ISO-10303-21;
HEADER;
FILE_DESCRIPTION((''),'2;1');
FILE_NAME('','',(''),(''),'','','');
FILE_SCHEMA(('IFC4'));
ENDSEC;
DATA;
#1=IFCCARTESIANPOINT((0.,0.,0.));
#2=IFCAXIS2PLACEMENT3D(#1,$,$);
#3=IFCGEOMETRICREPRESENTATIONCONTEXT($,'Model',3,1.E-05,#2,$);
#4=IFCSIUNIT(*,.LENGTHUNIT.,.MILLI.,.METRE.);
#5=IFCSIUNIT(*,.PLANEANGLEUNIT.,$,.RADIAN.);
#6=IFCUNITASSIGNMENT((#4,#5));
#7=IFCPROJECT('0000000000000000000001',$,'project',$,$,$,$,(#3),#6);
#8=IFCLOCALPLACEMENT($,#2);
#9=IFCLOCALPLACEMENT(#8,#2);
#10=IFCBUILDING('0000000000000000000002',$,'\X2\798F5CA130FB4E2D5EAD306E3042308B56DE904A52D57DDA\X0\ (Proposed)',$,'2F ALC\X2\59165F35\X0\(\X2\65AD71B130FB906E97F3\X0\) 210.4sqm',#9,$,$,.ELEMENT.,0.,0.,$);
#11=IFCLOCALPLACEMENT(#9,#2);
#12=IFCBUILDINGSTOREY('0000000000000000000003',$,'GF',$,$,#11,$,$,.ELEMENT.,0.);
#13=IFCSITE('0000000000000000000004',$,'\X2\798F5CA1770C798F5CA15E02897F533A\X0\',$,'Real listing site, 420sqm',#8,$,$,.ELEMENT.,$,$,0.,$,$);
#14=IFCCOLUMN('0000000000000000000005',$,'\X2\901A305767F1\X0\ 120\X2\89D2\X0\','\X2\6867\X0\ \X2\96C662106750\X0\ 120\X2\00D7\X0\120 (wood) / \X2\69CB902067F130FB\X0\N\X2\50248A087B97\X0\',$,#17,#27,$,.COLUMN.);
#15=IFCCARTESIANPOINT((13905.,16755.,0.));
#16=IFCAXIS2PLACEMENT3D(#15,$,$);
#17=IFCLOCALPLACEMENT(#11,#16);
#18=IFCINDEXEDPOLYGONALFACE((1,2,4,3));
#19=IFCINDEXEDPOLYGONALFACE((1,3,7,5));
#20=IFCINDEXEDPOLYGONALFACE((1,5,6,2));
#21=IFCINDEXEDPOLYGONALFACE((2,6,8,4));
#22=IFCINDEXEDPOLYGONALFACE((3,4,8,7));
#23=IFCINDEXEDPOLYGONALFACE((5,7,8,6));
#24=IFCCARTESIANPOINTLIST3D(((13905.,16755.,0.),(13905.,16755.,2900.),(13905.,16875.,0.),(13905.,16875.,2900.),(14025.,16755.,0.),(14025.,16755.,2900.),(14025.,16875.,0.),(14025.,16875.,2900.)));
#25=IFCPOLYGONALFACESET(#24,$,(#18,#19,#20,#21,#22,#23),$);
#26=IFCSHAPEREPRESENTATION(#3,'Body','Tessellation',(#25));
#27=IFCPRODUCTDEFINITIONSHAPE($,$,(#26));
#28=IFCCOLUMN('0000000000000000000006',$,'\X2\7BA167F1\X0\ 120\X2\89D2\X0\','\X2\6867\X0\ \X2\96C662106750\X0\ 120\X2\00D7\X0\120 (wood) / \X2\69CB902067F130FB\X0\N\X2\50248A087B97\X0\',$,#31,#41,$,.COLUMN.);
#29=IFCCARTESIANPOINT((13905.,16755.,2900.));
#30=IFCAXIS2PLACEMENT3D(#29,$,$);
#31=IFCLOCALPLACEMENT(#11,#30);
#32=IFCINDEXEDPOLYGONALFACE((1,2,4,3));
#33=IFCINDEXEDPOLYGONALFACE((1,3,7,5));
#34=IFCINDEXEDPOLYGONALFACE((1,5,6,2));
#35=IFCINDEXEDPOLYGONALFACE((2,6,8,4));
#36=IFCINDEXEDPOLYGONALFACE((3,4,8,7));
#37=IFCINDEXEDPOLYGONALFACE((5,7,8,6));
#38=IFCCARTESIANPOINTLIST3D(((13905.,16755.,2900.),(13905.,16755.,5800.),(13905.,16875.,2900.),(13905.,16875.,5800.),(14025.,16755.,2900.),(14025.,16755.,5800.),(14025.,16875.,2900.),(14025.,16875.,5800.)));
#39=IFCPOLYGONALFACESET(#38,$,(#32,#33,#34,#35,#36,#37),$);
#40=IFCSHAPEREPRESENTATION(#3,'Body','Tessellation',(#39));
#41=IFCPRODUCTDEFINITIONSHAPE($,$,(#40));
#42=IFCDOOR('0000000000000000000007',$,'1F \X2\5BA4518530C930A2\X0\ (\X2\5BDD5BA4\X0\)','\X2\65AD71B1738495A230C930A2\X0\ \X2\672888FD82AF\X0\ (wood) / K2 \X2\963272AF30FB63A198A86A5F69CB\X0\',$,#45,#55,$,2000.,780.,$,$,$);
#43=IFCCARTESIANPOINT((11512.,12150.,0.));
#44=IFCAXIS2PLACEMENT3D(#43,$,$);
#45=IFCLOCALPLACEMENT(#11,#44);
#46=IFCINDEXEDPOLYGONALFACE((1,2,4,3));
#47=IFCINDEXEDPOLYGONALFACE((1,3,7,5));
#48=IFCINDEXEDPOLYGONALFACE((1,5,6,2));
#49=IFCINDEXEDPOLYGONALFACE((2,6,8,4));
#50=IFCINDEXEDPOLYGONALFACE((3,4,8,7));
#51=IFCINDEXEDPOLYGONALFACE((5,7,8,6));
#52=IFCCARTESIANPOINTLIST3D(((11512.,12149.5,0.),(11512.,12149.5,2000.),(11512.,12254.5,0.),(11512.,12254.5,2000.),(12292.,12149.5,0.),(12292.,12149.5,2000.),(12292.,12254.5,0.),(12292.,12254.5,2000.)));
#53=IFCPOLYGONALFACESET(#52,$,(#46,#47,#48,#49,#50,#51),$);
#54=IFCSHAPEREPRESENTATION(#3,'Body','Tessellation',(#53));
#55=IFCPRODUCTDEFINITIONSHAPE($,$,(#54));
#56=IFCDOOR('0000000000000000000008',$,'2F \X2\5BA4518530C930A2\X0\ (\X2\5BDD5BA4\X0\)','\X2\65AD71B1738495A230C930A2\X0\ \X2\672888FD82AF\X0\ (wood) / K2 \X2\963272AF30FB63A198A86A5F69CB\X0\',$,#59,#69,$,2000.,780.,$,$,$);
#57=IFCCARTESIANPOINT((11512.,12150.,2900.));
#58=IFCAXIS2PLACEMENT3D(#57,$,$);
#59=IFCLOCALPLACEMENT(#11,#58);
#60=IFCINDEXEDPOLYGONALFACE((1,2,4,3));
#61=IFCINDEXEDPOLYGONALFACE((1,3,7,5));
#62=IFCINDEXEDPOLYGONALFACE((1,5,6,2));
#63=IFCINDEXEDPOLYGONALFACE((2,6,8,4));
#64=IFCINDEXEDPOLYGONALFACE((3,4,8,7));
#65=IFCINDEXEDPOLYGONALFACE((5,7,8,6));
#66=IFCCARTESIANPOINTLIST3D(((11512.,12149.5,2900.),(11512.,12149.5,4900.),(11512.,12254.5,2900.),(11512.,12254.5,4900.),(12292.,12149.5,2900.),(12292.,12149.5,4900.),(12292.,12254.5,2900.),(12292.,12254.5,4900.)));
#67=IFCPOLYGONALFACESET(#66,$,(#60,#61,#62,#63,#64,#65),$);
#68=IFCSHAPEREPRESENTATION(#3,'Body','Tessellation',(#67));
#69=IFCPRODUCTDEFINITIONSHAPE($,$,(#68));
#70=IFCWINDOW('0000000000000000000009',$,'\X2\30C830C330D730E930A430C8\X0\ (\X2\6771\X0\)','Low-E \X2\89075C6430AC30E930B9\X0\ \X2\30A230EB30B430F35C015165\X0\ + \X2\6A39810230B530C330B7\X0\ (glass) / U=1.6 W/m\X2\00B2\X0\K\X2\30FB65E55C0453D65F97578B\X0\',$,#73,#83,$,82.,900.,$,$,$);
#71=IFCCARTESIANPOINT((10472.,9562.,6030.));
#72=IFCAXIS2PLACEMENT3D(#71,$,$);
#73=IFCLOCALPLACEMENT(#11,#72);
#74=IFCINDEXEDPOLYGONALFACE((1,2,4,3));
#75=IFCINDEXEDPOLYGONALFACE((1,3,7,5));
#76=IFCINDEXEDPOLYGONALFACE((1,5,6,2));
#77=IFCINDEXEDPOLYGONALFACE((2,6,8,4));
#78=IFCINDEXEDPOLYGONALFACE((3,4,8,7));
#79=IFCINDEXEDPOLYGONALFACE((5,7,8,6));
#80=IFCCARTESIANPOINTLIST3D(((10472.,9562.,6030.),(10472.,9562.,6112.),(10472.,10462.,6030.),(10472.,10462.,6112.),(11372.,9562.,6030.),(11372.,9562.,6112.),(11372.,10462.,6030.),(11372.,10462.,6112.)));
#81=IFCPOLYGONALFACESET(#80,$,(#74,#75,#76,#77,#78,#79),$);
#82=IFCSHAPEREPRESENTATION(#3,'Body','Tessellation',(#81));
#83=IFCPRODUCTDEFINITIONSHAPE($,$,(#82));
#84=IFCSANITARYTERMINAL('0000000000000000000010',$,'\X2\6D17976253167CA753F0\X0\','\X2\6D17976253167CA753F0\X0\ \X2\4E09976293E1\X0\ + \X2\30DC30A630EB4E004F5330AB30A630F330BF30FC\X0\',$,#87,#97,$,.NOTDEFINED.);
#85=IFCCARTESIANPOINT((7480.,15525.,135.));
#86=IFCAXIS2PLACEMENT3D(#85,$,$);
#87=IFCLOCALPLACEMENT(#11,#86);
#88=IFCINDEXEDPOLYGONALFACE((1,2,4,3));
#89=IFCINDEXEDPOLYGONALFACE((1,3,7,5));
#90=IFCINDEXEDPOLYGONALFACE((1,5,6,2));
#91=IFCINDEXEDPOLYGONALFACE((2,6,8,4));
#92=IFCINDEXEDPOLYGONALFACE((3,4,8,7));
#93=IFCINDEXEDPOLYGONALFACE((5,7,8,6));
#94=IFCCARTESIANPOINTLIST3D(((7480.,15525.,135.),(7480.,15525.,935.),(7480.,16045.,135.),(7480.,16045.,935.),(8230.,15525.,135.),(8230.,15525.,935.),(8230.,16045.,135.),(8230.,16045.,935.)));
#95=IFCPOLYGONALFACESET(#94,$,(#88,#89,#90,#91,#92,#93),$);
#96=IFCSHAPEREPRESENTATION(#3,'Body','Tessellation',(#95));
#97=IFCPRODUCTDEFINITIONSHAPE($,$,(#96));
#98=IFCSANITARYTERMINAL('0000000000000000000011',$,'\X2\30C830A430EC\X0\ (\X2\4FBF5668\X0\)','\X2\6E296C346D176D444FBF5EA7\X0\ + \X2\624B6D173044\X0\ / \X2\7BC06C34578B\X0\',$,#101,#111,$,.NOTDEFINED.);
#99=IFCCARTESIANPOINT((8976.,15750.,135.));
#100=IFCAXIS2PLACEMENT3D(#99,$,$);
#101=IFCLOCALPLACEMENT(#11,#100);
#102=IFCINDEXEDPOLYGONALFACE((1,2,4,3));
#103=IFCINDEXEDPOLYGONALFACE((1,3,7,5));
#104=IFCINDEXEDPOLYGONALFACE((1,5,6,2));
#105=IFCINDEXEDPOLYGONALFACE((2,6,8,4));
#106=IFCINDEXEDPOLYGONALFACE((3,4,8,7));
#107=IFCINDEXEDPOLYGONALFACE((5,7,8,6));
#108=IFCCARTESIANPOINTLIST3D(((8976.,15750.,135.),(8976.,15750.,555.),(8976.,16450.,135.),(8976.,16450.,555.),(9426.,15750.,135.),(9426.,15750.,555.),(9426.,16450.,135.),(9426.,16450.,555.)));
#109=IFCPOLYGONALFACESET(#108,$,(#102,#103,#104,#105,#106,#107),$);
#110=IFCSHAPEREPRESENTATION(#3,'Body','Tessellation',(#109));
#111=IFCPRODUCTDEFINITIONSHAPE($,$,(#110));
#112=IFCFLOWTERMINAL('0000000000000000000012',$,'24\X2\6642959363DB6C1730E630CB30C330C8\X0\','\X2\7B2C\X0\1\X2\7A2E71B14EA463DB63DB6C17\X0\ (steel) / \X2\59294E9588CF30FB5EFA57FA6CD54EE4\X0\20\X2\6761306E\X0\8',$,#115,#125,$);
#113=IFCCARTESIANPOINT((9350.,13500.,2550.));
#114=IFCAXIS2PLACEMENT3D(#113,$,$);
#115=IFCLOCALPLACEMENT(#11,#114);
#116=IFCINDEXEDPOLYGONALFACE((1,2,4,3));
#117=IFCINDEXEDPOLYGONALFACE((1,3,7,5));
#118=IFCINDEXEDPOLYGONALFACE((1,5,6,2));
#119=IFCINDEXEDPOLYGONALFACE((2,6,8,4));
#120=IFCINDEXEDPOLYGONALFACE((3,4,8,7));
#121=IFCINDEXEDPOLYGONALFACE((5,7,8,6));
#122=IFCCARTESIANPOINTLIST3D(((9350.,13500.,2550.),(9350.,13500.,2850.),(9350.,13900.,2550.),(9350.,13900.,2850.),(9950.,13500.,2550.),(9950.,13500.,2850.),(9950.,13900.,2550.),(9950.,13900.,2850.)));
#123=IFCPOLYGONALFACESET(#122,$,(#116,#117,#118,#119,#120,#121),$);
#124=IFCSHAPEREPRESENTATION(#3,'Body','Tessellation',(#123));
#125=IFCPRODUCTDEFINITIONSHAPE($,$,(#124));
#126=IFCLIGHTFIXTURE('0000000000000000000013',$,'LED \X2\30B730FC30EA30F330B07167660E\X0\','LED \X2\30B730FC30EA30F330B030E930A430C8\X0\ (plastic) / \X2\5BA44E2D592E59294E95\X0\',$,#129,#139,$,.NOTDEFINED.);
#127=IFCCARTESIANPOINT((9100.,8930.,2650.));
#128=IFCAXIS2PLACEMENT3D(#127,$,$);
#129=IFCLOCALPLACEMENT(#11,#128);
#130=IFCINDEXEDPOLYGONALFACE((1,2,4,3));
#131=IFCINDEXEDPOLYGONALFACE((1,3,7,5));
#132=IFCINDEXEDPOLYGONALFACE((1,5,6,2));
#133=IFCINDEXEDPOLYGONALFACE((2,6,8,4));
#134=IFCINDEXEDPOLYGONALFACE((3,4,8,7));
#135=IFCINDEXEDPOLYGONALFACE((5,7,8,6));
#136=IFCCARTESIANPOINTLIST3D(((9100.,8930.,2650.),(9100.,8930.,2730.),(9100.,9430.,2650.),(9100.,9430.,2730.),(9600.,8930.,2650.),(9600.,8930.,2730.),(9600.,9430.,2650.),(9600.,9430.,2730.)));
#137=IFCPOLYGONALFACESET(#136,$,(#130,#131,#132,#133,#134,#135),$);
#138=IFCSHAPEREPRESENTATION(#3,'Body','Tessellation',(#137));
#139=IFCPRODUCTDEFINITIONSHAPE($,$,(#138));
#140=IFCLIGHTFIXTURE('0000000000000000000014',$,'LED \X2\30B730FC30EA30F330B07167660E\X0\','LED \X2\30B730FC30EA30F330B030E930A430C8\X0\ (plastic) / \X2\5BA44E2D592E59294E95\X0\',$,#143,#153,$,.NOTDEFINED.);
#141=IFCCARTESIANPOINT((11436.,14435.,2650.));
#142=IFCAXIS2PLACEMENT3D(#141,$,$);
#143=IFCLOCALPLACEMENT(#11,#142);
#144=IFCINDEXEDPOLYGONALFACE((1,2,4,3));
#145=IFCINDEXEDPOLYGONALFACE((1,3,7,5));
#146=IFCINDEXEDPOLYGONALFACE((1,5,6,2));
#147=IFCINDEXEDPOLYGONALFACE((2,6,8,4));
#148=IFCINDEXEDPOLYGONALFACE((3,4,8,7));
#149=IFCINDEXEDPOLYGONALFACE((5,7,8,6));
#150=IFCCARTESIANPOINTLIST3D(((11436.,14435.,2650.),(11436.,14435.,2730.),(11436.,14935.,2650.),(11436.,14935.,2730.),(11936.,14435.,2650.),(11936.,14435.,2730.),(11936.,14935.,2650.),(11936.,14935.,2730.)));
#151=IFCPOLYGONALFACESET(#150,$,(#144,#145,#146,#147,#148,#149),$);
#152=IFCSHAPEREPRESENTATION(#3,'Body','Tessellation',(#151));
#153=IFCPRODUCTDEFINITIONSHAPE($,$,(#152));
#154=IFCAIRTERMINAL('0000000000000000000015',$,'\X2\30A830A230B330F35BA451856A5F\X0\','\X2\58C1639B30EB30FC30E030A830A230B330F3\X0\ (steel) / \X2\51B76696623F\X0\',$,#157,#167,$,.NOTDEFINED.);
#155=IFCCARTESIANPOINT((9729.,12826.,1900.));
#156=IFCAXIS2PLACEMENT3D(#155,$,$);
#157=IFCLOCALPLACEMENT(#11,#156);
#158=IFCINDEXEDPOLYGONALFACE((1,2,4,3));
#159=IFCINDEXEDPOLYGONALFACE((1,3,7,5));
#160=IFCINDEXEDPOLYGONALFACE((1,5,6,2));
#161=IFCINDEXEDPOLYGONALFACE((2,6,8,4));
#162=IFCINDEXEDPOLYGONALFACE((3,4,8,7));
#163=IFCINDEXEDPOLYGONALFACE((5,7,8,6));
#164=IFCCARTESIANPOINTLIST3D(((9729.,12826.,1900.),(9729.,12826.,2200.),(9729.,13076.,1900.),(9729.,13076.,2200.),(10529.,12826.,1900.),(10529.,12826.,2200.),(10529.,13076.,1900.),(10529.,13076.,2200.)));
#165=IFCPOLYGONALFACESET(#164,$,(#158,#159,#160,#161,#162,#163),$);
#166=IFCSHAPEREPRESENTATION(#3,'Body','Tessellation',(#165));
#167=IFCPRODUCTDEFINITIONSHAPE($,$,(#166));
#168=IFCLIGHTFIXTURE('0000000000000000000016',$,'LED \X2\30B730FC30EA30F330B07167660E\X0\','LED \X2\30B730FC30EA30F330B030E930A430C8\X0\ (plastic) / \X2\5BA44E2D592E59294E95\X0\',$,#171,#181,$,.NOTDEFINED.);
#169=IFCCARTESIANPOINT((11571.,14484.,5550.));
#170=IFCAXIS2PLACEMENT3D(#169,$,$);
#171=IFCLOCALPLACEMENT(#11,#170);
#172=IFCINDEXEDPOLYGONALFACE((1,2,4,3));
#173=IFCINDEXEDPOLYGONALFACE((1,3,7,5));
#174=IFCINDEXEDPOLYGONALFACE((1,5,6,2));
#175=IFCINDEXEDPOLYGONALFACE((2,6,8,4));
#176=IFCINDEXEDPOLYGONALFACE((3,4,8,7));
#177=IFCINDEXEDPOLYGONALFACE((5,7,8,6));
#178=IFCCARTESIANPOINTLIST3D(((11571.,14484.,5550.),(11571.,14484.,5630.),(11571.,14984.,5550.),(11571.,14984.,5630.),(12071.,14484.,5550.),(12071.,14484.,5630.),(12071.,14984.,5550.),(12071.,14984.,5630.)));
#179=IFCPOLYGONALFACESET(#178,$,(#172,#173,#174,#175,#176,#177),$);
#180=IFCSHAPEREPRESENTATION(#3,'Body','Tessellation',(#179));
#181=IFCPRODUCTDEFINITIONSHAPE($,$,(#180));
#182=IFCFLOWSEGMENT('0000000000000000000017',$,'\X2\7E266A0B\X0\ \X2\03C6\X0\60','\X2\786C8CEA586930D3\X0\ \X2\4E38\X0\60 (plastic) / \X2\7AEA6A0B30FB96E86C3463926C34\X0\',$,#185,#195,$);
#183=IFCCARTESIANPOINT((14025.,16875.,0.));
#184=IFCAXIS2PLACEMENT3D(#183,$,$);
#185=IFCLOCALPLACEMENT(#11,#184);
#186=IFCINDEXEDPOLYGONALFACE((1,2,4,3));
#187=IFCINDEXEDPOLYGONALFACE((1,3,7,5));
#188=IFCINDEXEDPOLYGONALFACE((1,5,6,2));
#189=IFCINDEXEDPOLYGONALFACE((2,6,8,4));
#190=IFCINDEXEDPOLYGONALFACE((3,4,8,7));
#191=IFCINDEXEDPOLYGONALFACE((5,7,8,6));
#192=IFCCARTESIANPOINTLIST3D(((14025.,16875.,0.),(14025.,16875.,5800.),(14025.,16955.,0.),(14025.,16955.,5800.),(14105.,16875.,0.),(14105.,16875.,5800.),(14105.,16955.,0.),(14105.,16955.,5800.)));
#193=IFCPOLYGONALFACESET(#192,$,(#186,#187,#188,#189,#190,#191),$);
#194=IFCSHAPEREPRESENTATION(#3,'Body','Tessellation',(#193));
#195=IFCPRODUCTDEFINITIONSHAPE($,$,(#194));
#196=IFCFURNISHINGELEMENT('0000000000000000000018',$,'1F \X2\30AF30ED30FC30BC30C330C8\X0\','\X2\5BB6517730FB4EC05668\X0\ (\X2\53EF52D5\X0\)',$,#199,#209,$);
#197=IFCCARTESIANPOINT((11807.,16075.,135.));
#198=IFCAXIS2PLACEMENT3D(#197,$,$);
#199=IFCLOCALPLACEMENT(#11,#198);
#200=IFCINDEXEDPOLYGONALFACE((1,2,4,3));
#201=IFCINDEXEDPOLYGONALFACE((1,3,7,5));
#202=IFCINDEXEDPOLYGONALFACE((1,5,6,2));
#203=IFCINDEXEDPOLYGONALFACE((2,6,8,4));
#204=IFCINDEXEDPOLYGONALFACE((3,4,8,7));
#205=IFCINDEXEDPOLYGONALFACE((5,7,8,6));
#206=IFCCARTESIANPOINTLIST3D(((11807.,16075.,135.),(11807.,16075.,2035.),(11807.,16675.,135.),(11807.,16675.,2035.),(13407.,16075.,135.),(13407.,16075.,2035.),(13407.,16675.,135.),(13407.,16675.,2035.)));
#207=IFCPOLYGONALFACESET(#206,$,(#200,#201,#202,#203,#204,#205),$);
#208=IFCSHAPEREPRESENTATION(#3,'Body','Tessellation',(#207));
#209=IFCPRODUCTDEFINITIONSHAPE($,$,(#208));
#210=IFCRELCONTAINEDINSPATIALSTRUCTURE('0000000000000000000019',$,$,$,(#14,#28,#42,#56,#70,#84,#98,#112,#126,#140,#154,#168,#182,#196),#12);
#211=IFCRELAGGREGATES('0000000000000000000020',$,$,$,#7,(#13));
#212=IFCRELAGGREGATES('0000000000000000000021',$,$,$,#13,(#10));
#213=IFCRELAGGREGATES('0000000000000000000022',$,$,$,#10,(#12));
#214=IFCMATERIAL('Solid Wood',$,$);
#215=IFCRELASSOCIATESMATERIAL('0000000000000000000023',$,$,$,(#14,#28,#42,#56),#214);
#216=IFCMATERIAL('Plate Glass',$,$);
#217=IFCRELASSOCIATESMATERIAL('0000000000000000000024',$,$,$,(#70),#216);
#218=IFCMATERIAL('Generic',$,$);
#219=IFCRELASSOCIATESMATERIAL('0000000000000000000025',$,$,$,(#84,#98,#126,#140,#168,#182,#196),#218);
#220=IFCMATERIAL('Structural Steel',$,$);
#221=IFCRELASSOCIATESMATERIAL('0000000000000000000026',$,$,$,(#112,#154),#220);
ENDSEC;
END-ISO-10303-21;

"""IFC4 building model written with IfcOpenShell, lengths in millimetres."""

from ifc_helpers import new_model, si_unit, frame, frame_2d, origin, place, context, project, spatial, rectangle, extrude, material, element, save


model = new_model("IFC4")

# Units and contexts
model_context = context("Model", 3, precision=1e-05, world=origin())
ifc_project = project(units=[si_unit("LENGTHUNIT", "METRE", prefix="MILLI"), si_unit("PLANEANGLEUNIT", "RADIAN")], contexts=[model_context])

# Site, building, storey
site_placement = place(None, origin())
site = spatial("IfcSite", under=ifc_project, at=site_placement, Name="福岡県福岡市西区", ObjectType="Real listing site, 420sqm", CompositionType="ELEMENT", RefElevation=0.0)
building_placement = place(site_placement, origin())
building = spatial("IfcBuilding", under=site, at=building_placement, Name="福岡・中庭のある回遊動線 (Proposed)", ObjectType="2F ALC外張(断熱・遮音) 210.4sqm", CompositionType="ELEMENT", ElevationOfRefHeight=0.0, ElevationOfTerrain=0.0)
storey_placement = place(building_placement, origin())
storey = spatial("IfcBuildingStorey", under=building, at=storey_placement, Name="GF", CompositionType="ELEMENT", Elevation=0.0)

# Columns
ifc_material_1 = material(Name="Solid Wood")
column_1_placement = place(storey_placement, frame((13905.0, 16755.0, 0.0)))
element("IfcColumn", 1, at=column_1_placement, inside=storey, material=ifc_material_1, Name="通し柱 120角", Description="桧 集成材 120×120 (wood) / 構造柱・N値計算", PredefinedType="COLUMN", context=model_context, shape_type="SweptSolid", body=[
    extrude(rectangle(XDim=120.0, YDim=120.0, at=frame_2d((60.0, 60.0))), frame((13905.0, 16755.0, 0.0)), (0.0, 0.0, 1.0), 2900.0),
])
column_2_placement = place(storey_placement, frame((13905.0, 16755.0, 2900.0)))
element("IfcColumn", 2, at=column_2_placement, inside=storey, material=ifc_material_1, Name="管柱 120角", Description="桧 集成材 120×120 (wood) / 構造柱・N値計算", PredefinedType="COLUMN", context=model_context, shape_type="SweptSolid", body=[
    extrude(rectangle(XDim=120.0, YDim=120.0, at=frame_2d((60.0, 60.0))), frame((13905.0, 16755.0, 2900.0)), (0.0, 0.0, 1.0), 2900.0),
])

# Door
door_1_placement = place(storey_placement, frame((11512.0, 12150.0, 0.0)))
element("IfcDoor", 3, at=door_1_placement, inside=storey, material=ifc_material_1, Name="1F 室内ドア (寝室)", Description="断熱玄関ドア 木製芯 (wood) / K2 防犯・採風機構", OverallHeight=2000.0, OverallWidth=780.0, context=model_context, shape_type="SweptSolid", body=[
    extrude(rectangle(XDim=780.0, YDim=105.0, at=frame_2d((390.0, 52.0))), frame((11512.0, 12150.0, 0.0)), (0.0, 0.0, 1.0), 2000.0),
])

# Door
door_2_placement = place(storey_placement, frame((11512.0, 12150.0, 2900.0)))
element("IfcDoor", 4, at=door_2_placement, inside=storey, material=ifc_material_1, Name="2F 室内ドア (寝室)", Description="断熱玄関ドア 木製芯 (wood) / K2 防犯・採風機構", OverallHeight=2000.0, OverallWidth=780.0, context=model_context, shape_type="SweptSolid", body=[
    extrude(rectangle(XDim=780.0, YDim=105.0, at=frame_2d((390.0, 52.0))), frame((11512.0, 12150.0, 2900.0)), (0.0, 0.0, 1.0), 2000.0),
])

# Window
ifc_material_2 = material(Name="Plate Glass")
window_placement = place(storey_placement, frame((10472.0, 9562.0, 6030.0)))
element("IfcWindow", 5, at=window_placement, inside=storey, material=ifc_material_2, Name="トップライト (東)", Description="Low-E 複層ガラス アルゴン封入 + 樹脂サッシ (glass) / U=1.6 W/m²K・日射取得型", OverallHeight=82.0, OverallWidth=900.0, context=model_context, shape_type="SweptSolid", body=[
    extrude(rectangle(XDim=900.0, YDim=900.0, at=frame_2d((450.0, 450.0))), frame((10472.0, 9562.0, 6030.0)), (0.0, 0.0, 1.0), 82.0),
])

# Sanitary terminals
ifc_material_3 = material(Name="Generic")
sanitary_terminal_1_placement = place(storey_placement, frame((7480.0, 15525.0, 135.0)))
element("IfcSanitaryTerminal", 6, at=sanitary_terminal_1_placement, inside=storey, material=ifc_material_3, Name="洗面化粧台", Description="洗面化粧台 三面鏡 + ボウル一体カウンター", PredefinedType="NOTDEFINED", context=model_context, shape_type="SweptSolid", body=[
    extrude(rectangle(XDim=750.0, YDim=520.0, at=frame_2d((375.0, 260.0))), frame((7480.0, 15525.0, 135.0)), (0.0, 0.0, 1.0), 800.0),
])
sanitary_terminal_2_placement = place(storey_placement, frame((8976.0, 15750.0, 135.0)))
element("IfcSanitaryTerminal", 7, at=sanitary_terminal_2_placement, inside=storey, material=ifc_material_3, Name="トイレ (便器)", Description="温水洗浄便座 + 手洗い / 節水型", PredefinedType="NOTDEFINED", context=model_context, shape_type="SweptSolid", body=[
    extrude(rectangle(XDim=450.0, YDim=700.0, at=frame_2d((225.0, 350.0))), frame((8976.0, 15750.0, 135.0)), (0.0, 0.0, 1.0), 420.0),
])

# Flow terminal
ifc_material_4 = material(Name="Structural Steel")
flow_terminal_placement = place(storey_placement, frame((9350.0, 13500.0, 2550.0)))
element("IfcFlowTerminal", 8, at=flow_terminal_placement, inside=storey, material=ifc_material_4, Name="24時間換気ユニット", Description="第1種熱交換換気 (steel) / 天井裏・建基法令20条の8", context=model_context, shape_type="SweptSolid", body=[
    extrude(rectangle(XDim=600.0, YDim=400.0, at=frame_2d((300.0, 200.0))), frame((9350.0, 13500.0, 2550.0)), (0.0, 0.0, 1.0), 300.0),
])

# Light fixtures
light_fixture_1_placement = place(storey_placement, frame((9100.0, 8930.0, 2650.0)))
element("IfcLightFixture", 9, at=light_fixture_1_placement, inside=storey, material=ifc_material_3, Name="LED シーリング照明", Description="LED シーリングライト (plastic) / 室中央天井", PredefinedType="NOTDEFINED", context=model_context, shape_type="SweptSolid", body=[
    extrude(rectangle(XDim=500.0, YDim=500.0, at=frame_2d((250.0, 250.0))), frame((9100.0, 8930.0, 2650.0)), (0.0, 0.0, 1.0), 80.0),
])
light_fixture_2_placement = place(storey_placement, frame((11436.0, 14435.0, 2650.0)))
element("IfcLightFixture", 10, at=light_fixture_2_placement, inside=storey, material=ifc_material_3, Name="LED シーリング照明", Description="LED シーリングライト (plastic) / 室中央天井", PredefinedType="NOTDEFINED", context=model_context, shape_type="SweptSolid", body=[
    extrude(rectangle(XDim=500.0, YDim=500.0, at=frame_2d((250.0, 250.0))), frame((11436.0, 14435.0, 2650.0)), (0.0, 0.0, 1.0), 80.0),
])

# Air terminal
air_terminal_placement = place(storey_placement, frame((9729.0, 12826.0, 1900.0)))
element("IfcAirTerminal", 11, at=air_terminal_placement, inside=storey, material=ifc_material_4, Name="エアコン室内機", Description="壁掛ルームエアコン (steel) / 冷暖房", PredefinedType="NOTDEFINED", context=model_context, shape_type="SweptSolid", body=[
    extrude(rectangle(XDim=800.0, YDim=250.0, at=frame_2d((400.0, 125.0))), frame((9729.0, 12826.0, 1900.0)), (0.0, 0.0, 1.0), 300.0),
])

# Light fixture
light_fixture_3_placement = place(storey_placement, frame((11571.0, 14484.0, 5550.0)))
element("IfcLightFixture", 12, at=light_fixture_3_placement, inside=storey, material=ifc_material_3, Name="LED シーリング照明", Description="LED シーリングライト (plastic) / 室中央天井", PredefinedType="NOTDEFINED", context=model_context, shape_type="SweptSolid", body=[
    extrude(rectangle(XDim=500.0, YDim=500.0, at=frame_2d((250.0, 250.0))), frame((11571.0, 14484.0, 5550.0)), (0.0, 0.0, 1.0), 80.0),
])

# Flow segment
flow_segment_placement = place(storey_placement, frame((14025.0, 16875.0, 0.0)))
element("IfcFlowSegment", 13, at=flow_segment_placement, inside=storey, material=ifc_material_3, Name="縦樋 φ60", Description="硬質塩ビ 丸60 (plastic) / 竪樋・雨水排水", context=model_context, shape_type="SweptSolid", body=[
    extrude(rectangle(XDim=80.0, YDim=80.0, at=frame_2d((40.0, 40.0))), frame((14025.0, 16875.0, 0.0)), (0.0, 0.0, 1.0), 5800.0),
])

# Furnishing element
furnishing_1_placement = place(storey_placement, frame((11807.0, 16075.0, 135.0)))
element("IfcFurnishingElement", 14, at=furnishing_1_placement, inside=storey, material=ifc_material_3, Name="1F クローゼット", Description="家具・什器 (可動)", context=model_context, shape_type="SweptSolid", body=[
    extrude(rectangle(XDim=1600.0, YDim=600.0, at=frame_2d((800.0, 300.0))), frame((11807.0, 16075.0, 135.0)), (0.0, 0.0, 1.0), 1900.0),
])

save(model, "model.ifc")
